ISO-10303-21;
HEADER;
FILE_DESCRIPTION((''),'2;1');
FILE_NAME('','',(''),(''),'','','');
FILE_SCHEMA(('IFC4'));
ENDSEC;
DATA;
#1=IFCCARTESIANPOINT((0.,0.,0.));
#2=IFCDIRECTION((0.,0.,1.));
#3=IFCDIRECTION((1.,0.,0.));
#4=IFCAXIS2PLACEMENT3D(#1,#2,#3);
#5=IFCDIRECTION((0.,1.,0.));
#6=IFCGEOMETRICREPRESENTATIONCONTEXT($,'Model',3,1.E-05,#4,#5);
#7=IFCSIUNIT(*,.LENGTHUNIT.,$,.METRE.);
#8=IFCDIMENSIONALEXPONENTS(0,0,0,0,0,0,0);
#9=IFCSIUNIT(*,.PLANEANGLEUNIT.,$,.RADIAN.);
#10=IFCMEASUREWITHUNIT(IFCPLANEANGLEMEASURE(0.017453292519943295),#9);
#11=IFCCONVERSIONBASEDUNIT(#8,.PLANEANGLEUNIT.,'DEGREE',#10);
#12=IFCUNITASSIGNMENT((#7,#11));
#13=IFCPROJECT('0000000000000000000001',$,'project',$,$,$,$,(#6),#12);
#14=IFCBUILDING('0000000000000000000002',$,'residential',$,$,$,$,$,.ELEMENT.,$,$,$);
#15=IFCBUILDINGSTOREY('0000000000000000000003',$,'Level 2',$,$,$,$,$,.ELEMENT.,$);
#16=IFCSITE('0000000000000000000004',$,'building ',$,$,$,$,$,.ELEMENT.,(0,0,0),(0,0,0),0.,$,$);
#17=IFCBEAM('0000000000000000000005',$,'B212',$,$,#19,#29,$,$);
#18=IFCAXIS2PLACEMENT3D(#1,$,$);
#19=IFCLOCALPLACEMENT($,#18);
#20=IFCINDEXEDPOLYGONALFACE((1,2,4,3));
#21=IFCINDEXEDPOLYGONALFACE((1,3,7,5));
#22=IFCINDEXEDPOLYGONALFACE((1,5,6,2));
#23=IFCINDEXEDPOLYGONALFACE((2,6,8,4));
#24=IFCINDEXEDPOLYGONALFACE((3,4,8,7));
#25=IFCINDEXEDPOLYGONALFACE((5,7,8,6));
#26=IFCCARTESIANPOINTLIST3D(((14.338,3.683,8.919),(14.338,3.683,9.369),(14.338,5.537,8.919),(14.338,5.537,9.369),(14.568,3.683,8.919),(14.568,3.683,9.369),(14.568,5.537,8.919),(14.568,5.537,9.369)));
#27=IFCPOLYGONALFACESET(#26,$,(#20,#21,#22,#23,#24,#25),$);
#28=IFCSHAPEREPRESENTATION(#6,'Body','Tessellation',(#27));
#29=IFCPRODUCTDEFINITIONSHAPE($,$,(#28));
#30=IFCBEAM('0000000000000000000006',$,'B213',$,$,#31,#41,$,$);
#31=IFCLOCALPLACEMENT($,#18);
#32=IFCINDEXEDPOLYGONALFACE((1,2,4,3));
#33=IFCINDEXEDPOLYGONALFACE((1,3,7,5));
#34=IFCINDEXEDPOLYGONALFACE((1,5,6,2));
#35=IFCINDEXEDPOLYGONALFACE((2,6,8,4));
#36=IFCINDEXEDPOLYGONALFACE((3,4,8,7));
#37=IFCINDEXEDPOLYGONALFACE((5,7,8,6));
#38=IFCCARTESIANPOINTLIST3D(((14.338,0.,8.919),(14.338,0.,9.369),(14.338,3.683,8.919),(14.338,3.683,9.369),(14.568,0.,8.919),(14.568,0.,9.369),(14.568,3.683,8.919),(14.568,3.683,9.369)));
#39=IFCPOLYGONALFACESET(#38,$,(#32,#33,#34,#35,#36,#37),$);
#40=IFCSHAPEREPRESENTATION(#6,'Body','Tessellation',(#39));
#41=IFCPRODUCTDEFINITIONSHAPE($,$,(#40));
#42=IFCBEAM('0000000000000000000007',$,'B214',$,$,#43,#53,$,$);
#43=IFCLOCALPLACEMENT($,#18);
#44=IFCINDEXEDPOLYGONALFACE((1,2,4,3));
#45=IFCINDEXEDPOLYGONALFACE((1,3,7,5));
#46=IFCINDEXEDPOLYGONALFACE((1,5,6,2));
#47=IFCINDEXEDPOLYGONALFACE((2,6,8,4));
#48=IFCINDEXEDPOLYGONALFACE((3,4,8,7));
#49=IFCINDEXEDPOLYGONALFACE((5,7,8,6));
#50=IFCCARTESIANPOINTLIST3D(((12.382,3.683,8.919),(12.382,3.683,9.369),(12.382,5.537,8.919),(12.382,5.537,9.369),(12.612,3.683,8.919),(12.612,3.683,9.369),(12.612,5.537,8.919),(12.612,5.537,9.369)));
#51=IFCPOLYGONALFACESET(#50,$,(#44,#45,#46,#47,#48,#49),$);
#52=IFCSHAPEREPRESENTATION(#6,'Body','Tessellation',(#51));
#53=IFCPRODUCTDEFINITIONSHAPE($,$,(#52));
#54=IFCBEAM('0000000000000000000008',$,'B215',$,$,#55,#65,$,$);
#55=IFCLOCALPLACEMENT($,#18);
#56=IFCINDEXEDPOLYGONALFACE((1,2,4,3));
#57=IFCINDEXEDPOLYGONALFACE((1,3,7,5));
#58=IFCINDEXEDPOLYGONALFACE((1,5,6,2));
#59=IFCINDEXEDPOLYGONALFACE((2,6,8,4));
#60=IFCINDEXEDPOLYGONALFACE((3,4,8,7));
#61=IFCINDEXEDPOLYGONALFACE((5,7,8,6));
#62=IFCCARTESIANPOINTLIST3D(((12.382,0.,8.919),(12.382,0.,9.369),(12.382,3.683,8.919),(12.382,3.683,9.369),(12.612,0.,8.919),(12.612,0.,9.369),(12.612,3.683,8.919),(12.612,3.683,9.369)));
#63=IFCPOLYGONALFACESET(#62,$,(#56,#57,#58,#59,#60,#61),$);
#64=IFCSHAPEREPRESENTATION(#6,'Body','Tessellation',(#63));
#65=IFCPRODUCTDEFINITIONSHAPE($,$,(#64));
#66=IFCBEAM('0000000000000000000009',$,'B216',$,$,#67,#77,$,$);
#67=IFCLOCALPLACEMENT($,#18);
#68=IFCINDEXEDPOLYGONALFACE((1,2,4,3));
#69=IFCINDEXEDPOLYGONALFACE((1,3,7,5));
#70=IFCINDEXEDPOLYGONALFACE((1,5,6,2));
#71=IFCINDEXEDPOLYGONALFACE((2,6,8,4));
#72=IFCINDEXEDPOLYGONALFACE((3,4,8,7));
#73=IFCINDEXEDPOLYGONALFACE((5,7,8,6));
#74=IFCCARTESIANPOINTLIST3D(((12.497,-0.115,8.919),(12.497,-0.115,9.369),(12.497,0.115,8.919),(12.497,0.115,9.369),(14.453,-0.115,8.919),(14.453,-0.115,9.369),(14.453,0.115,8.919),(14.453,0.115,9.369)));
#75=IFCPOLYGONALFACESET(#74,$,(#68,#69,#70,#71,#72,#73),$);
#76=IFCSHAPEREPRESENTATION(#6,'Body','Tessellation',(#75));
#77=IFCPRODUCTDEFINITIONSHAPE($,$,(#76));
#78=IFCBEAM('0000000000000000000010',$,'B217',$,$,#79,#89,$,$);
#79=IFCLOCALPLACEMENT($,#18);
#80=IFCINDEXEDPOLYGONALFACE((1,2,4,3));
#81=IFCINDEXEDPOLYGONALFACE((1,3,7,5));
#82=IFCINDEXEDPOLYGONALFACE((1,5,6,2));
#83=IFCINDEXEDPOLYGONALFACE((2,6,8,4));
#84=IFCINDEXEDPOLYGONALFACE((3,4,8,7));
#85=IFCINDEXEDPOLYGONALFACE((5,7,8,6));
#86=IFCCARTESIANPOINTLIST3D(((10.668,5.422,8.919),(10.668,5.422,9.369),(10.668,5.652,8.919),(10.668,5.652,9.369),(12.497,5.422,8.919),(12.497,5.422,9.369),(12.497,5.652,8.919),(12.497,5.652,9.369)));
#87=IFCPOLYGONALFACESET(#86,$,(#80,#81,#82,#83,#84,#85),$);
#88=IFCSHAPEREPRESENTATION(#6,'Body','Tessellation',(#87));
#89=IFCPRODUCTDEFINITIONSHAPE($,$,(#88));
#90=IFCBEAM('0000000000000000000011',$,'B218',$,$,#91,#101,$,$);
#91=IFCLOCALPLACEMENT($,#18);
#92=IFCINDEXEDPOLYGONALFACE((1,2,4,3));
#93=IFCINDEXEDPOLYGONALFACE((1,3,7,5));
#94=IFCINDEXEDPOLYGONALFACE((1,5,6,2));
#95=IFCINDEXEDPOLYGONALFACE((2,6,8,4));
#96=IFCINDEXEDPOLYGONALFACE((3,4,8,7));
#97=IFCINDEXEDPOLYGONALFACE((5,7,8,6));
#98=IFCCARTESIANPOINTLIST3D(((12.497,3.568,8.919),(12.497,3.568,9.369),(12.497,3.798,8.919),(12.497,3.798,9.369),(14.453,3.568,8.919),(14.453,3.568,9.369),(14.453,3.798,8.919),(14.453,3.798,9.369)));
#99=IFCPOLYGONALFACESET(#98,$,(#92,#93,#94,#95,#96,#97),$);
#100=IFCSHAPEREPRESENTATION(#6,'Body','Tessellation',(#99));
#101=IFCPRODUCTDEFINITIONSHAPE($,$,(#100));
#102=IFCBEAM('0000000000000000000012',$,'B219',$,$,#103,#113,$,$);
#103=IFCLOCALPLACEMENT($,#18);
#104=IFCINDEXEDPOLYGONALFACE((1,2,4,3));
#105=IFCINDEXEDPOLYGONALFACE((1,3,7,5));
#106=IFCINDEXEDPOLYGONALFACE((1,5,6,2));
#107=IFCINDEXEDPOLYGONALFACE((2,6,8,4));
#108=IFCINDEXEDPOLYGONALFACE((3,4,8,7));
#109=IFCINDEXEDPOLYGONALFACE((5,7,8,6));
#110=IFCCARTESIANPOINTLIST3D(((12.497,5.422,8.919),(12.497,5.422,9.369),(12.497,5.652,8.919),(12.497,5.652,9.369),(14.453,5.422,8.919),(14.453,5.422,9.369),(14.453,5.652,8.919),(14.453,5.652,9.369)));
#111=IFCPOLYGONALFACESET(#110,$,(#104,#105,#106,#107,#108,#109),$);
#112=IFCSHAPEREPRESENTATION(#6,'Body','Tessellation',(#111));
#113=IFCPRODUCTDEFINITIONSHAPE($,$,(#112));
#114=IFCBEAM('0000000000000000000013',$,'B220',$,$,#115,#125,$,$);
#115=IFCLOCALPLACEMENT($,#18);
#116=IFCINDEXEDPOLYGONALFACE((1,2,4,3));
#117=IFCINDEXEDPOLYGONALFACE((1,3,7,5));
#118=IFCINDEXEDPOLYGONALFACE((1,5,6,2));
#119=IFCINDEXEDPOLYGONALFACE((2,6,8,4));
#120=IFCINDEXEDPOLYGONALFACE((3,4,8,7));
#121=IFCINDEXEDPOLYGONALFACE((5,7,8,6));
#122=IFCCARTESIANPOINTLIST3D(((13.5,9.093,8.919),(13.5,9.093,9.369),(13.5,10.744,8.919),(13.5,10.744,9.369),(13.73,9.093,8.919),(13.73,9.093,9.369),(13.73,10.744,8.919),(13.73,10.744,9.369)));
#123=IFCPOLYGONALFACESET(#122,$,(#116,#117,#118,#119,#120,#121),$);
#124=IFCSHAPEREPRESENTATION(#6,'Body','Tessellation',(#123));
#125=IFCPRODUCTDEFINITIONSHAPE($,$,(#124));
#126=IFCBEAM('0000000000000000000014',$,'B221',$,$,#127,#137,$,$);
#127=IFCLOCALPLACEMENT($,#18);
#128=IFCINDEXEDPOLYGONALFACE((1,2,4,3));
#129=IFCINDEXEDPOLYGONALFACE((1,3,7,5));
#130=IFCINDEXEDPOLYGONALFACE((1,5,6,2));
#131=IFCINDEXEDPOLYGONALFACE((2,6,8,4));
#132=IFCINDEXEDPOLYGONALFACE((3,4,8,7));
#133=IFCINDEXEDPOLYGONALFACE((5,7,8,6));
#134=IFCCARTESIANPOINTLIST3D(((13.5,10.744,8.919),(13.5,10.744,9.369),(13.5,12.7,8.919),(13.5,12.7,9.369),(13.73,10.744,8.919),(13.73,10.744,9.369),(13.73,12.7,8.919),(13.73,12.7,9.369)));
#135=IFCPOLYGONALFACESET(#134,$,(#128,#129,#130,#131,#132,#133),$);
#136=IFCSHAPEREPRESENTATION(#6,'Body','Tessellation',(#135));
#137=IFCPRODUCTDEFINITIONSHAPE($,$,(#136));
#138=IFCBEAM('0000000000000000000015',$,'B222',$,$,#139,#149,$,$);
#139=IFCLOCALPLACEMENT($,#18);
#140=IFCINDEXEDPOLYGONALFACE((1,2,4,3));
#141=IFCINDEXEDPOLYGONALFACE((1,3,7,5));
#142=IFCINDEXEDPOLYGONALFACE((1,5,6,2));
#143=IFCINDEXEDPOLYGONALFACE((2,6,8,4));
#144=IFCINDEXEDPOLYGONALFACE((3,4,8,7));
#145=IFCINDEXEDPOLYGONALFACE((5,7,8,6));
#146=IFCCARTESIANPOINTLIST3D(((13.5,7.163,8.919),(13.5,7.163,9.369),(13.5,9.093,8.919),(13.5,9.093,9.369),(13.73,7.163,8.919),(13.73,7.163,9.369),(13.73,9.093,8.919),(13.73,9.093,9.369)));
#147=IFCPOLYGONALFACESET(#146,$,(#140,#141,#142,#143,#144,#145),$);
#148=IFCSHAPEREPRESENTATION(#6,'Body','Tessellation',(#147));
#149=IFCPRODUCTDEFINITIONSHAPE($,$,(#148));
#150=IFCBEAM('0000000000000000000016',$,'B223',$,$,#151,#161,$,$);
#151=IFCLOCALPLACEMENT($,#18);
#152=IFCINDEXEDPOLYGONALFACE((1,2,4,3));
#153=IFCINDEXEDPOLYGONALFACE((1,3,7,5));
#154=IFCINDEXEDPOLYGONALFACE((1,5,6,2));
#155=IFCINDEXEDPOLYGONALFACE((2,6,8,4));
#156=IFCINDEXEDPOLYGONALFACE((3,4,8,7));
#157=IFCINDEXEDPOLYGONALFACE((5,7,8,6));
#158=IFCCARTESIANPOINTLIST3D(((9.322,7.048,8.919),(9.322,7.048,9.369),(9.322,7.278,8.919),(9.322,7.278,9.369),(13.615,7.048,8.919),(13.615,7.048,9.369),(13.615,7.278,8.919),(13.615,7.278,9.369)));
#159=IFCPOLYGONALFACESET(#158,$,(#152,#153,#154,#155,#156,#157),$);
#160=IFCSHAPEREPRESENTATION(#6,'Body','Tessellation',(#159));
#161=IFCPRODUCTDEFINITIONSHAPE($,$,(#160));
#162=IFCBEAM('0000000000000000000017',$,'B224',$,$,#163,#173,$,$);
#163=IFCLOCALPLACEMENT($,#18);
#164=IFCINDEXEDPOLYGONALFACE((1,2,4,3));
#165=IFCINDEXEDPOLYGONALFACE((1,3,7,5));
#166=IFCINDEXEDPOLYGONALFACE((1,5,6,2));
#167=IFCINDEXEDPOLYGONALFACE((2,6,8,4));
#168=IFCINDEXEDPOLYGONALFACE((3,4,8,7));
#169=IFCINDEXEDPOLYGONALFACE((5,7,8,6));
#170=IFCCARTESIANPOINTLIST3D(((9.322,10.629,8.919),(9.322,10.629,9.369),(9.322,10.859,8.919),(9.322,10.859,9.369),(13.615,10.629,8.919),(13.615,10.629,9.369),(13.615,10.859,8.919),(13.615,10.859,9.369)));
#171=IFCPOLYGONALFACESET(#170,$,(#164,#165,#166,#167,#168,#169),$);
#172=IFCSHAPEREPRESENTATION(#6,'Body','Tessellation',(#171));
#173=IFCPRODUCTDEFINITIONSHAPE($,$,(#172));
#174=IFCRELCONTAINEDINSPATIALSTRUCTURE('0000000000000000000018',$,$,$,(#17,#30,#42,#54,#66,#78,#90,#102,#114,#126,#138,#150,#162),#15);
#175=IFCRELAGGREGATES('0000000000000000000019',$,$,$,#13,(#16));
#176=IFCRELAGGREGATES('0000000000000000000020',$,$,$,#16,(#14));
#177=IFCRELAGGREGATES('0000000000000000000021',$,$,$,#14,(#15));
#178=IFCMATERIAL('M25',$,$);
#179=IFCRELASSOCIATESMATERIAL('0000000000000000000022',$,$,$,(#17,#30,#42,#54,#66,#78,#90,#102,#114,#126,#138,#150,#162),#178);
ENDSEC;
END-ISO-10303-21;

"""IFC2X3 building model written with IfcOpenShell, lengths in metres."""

from ifc_helpers import new_model, entity, si_unit, converted_unit, direction, frame, frame_2d, origin_with_axes, place, context, project, spatial, rectangle, extrude, material, element, save


model = new_model("IFC2X3")

# Units and contexts
model_context = context("Model", 3, precision=1e-05, world=origin_with_axes(), true_north=direction((0.0, 1.0, 0.0)))
ifc_project = project(units=[si_unit("LENGTHUNIT", "METRE"), converted_unit("PLANEANGLEUNIT", "DEGREE", entity("IfcPlaneAngleMeasure", 0.017453292519943295), si_unit("PLANEANGLEUNIT", "RADIAN"), dimensions=[0, 0, 0, 0, 0, 0, 0])], contexts=[model_context])

# Site, building, storey
site = spatial("IfcSite", under=ifc_project, Name="building ", CompositionType="ELEMENT", RefLatitude=(0, 0, 0), RefLongitude=(0, 0, 0), RefElevation=0.0)
building = spatial("IfcBuilding", under=site, Name="residential", CompositionType="ELEMENT")
storey = spatial("IfcBuildingStorey", under=building, Name="Level 2", CompositionType="ELEMENT")

# Shared definitions
ifc_material = material(Name="M25")
placement = place(None, origin_with_axes())

# Beams
element("IfcBeam", 1, at=placement, inside=storey, material=ifc_material, Name="B212", context=model_context, shape_type="SweptSolid", body=[
    extrude(rectangle(XDim=0.23, YDim=0.45, at=frame_2d((0.0, 0.0), x_axis=(0.0, 1.0, 0.0))), frame((14.453, 3.683, 9.144), z_axis=(0.0, 1.0, 0.0), x_axis=(0.0, 0.0, -1.0)), (0.0, 0.0, 1.0), 1.854),
])
element("IfcBeam", 2, at=placement, inside=storey, material=ifc_material, Name="B213", context=model_context, shape_type="SweptSolid", body=[
    extrude(rectangle(XDim=0.23, YDim=0.45, at=frame_2d((0.0, 0.0), x_axis=(0.0, 1.0, 0.0))), frame((14.453, 0.0, 9.144), z_axis=(0.0, 1.0, 0.0), x_axis=(0.0, 0.0, -1.0)), (0.0, 0.0, 1.0), 3.683),
])
element("IfcBeam", 3, at=placement, inside=storey, material=ifc_material, Name="B214", context=model_context, shape_type="SweptSolid", body=[
    extrude(rectangle(XDim=0.23, YDim=0.45, at=frame_2d((0.0, 0.0), x_axis=(0.0, 1.0, 0.0))), frame((12.497, 3.683, 9.144), z_axis=(0.0, 1.0, 0.0), x_axis=(0.0, 0.0, -1.0)), (0.0, 0.0, 1.0), 1.854),
])
element("IfcBeam", 4, at=placement, inside=storey, material=ifc_material, Name="B215", context=model_context, shape_type="SweptSolid", body=[
    extrude(rectangle(XDim=0.23, YDim=0.45, at=frame_2d((0.0, 0.0), x_axis=(0.0, 1.0, 0.0))), frame((12.497, 0.0, 9.144), z_axis=(0.0, 1.0, 0.0), x_axis=(0.0, 0.0, -1.0)), (0.0, 0.0, 1.0), 3.683),
])
element("IfcBeam", 5, at=placement, inside=storey, material=ifc_material, Name="B216", context=model_context, shape_type="SweptSolid", body=[
    extrude(rectangle(XDim=0.23, YDim=0.45, at=frame_2d((0.0, 0.0), x_axis=(0.0, 1.0, 0.0))), frame((12.497, 0.0, 9.144), z_axis=(1.0, 0.0, 0.0), x_axis=(0.0, 0.0, -1.0)), (0.0, 0.0, 1.0), 1.956),
])
element("IfcBeam", 6, at=placement, inside=storey, material=ifc_material, Name="B217", context=model_context, shape_type="SweptSolid", body=[
    extrude(rectangle(XDim=0.23, YDim=0.45, at=frame_2d((0.0, 0.0), x_axis=(0.0, 1.0, 0.0))), frame((10.668, 5.537, 9.144), z_axis=(1.0, 0.0, 0.0), x_axis=(0.0, 0.0, -1.0)), (0.0, 0.0, 1.0), 1.829),
])
element("IfcBeam", 7, at=placement, inside=storey, material=ifc_material, Name="B218", context=model_context, shape_type="SweptSolid", body=[
    extrude(rectangle(XDim=0.23, YDim=0.45, at=frame_2d((0.0, 0.0), x_axis=(0.0, 1.0, 0.0))), frame((12.497, 3.683, 9.144), z_axis=(1.0, 0.0, 0.0), x_axis=(0.0, 0.0, -1.0)), (0.0, 0.0, 1.0), 1.956),
])
element("IfcBeam", 8, at=placement, inside=storey, material=ifc_material, Name="B219", context=model_context, shape_type="SweptSolid", body=[
    extrude(rectangle(XDim=0.23, YDim=0.45, at=frame_2d((0.0, 0.0), x_axis=(0.0, 1.0, 0.0))), frame((12.497, 5.537, 9.144), z_axis=(1.0, 0.0, 0.0), x_axis=(0.0, 0.0, -1.0)), (0.0, 0.0, 1.0), 1.956),
])
element("IfcBeam", 9, at=placement, inside=storey, material=ifc_material, Name="B220", context=model_context, shape_type="SweptSolid", body=[
    extrude(rectangle(XDim=0.23, YDim=0.45, at=frame_2d((0.0, 0.0), x_axis=(0.0, 1.0, 0.0))), frame((13.615, 9.093, 9.144), z_axis=(0.0, 1.0, 0.0), x_axis=(0.0, 0.0, -1.0)), (0.0, 0.0, 1.0), 1.651),
])
element("IfcBeam", 10, at=placement, inside=storey, material=ifc_material, Name="B221", context=model_context, shape_type="SweptSolid", body=[
    extrude(rectangle(XDim=0.23, YDim=0.45, at=frame_2d((0.0, 0.0), x_axis=(0.0, 1.0, 0.0))), frame((13.615, 10.744, 9.144), z_axis=(0.0, 1.0, 0.0), x_axis=(0.0, 0.0, -1.0)), (0.0, 0.0, 1.0), 1.956),
])
element("IfcBeam", 11, at=placement, inside=storey, material=ifc_material, Name="B222", context=model_context, shape_type="SweptSolid", body=[
    extrude(rectangle(XDim=0.23, YDim=0.45, at=frame_2d((0.0, 0.0), x_axis=(0.0, 1.0, 0.0))), frame((13.615, 7.163, 9.144), z_axis=(0.0, 1.0, 0.0), x_axis=(0.0, 0.0, -1.0)), (0.0, 0.0, 1.0), 1.93),
])
element("IfcBeam", 12, at=placement, inside=storey, material=ifc_material, Name="B223", context=model_context, shape_type="SweptSolid", body=[
    extrude(rectangle(XDim=0.23, YDim=0.45, at=frame_2d((0.0, 0.0), x_axis=(0.0, 1.0, 0.0))), frame((9.322, 7.163, 9.144), z_axis=(1.0, 0.0, 0.0), x_axis=(0.0, 0.0, -1.0)), (0.0, 0.0, 1.0), 4.293),
])
element("IfcBeam", 13, at=placement, inside=storey, material=ifc_material, Name="B224", context=model_context, shape_type="SweptSolid", body=[
    extrude(rectangle(XDim=0.23, YDim=0.45, at=frame_2d((0.0, 0.0), x_axis=(0.0, 1.0, 0.0))), frame((9.322, 10.744, 9.144), z_axis=(1.0, 0.0, 0.0), x_axis=(0.0, 0.0, -1.0)), (0.0, 0.0, 1.0), 4.293),
])

save(model, "model.ifc")
